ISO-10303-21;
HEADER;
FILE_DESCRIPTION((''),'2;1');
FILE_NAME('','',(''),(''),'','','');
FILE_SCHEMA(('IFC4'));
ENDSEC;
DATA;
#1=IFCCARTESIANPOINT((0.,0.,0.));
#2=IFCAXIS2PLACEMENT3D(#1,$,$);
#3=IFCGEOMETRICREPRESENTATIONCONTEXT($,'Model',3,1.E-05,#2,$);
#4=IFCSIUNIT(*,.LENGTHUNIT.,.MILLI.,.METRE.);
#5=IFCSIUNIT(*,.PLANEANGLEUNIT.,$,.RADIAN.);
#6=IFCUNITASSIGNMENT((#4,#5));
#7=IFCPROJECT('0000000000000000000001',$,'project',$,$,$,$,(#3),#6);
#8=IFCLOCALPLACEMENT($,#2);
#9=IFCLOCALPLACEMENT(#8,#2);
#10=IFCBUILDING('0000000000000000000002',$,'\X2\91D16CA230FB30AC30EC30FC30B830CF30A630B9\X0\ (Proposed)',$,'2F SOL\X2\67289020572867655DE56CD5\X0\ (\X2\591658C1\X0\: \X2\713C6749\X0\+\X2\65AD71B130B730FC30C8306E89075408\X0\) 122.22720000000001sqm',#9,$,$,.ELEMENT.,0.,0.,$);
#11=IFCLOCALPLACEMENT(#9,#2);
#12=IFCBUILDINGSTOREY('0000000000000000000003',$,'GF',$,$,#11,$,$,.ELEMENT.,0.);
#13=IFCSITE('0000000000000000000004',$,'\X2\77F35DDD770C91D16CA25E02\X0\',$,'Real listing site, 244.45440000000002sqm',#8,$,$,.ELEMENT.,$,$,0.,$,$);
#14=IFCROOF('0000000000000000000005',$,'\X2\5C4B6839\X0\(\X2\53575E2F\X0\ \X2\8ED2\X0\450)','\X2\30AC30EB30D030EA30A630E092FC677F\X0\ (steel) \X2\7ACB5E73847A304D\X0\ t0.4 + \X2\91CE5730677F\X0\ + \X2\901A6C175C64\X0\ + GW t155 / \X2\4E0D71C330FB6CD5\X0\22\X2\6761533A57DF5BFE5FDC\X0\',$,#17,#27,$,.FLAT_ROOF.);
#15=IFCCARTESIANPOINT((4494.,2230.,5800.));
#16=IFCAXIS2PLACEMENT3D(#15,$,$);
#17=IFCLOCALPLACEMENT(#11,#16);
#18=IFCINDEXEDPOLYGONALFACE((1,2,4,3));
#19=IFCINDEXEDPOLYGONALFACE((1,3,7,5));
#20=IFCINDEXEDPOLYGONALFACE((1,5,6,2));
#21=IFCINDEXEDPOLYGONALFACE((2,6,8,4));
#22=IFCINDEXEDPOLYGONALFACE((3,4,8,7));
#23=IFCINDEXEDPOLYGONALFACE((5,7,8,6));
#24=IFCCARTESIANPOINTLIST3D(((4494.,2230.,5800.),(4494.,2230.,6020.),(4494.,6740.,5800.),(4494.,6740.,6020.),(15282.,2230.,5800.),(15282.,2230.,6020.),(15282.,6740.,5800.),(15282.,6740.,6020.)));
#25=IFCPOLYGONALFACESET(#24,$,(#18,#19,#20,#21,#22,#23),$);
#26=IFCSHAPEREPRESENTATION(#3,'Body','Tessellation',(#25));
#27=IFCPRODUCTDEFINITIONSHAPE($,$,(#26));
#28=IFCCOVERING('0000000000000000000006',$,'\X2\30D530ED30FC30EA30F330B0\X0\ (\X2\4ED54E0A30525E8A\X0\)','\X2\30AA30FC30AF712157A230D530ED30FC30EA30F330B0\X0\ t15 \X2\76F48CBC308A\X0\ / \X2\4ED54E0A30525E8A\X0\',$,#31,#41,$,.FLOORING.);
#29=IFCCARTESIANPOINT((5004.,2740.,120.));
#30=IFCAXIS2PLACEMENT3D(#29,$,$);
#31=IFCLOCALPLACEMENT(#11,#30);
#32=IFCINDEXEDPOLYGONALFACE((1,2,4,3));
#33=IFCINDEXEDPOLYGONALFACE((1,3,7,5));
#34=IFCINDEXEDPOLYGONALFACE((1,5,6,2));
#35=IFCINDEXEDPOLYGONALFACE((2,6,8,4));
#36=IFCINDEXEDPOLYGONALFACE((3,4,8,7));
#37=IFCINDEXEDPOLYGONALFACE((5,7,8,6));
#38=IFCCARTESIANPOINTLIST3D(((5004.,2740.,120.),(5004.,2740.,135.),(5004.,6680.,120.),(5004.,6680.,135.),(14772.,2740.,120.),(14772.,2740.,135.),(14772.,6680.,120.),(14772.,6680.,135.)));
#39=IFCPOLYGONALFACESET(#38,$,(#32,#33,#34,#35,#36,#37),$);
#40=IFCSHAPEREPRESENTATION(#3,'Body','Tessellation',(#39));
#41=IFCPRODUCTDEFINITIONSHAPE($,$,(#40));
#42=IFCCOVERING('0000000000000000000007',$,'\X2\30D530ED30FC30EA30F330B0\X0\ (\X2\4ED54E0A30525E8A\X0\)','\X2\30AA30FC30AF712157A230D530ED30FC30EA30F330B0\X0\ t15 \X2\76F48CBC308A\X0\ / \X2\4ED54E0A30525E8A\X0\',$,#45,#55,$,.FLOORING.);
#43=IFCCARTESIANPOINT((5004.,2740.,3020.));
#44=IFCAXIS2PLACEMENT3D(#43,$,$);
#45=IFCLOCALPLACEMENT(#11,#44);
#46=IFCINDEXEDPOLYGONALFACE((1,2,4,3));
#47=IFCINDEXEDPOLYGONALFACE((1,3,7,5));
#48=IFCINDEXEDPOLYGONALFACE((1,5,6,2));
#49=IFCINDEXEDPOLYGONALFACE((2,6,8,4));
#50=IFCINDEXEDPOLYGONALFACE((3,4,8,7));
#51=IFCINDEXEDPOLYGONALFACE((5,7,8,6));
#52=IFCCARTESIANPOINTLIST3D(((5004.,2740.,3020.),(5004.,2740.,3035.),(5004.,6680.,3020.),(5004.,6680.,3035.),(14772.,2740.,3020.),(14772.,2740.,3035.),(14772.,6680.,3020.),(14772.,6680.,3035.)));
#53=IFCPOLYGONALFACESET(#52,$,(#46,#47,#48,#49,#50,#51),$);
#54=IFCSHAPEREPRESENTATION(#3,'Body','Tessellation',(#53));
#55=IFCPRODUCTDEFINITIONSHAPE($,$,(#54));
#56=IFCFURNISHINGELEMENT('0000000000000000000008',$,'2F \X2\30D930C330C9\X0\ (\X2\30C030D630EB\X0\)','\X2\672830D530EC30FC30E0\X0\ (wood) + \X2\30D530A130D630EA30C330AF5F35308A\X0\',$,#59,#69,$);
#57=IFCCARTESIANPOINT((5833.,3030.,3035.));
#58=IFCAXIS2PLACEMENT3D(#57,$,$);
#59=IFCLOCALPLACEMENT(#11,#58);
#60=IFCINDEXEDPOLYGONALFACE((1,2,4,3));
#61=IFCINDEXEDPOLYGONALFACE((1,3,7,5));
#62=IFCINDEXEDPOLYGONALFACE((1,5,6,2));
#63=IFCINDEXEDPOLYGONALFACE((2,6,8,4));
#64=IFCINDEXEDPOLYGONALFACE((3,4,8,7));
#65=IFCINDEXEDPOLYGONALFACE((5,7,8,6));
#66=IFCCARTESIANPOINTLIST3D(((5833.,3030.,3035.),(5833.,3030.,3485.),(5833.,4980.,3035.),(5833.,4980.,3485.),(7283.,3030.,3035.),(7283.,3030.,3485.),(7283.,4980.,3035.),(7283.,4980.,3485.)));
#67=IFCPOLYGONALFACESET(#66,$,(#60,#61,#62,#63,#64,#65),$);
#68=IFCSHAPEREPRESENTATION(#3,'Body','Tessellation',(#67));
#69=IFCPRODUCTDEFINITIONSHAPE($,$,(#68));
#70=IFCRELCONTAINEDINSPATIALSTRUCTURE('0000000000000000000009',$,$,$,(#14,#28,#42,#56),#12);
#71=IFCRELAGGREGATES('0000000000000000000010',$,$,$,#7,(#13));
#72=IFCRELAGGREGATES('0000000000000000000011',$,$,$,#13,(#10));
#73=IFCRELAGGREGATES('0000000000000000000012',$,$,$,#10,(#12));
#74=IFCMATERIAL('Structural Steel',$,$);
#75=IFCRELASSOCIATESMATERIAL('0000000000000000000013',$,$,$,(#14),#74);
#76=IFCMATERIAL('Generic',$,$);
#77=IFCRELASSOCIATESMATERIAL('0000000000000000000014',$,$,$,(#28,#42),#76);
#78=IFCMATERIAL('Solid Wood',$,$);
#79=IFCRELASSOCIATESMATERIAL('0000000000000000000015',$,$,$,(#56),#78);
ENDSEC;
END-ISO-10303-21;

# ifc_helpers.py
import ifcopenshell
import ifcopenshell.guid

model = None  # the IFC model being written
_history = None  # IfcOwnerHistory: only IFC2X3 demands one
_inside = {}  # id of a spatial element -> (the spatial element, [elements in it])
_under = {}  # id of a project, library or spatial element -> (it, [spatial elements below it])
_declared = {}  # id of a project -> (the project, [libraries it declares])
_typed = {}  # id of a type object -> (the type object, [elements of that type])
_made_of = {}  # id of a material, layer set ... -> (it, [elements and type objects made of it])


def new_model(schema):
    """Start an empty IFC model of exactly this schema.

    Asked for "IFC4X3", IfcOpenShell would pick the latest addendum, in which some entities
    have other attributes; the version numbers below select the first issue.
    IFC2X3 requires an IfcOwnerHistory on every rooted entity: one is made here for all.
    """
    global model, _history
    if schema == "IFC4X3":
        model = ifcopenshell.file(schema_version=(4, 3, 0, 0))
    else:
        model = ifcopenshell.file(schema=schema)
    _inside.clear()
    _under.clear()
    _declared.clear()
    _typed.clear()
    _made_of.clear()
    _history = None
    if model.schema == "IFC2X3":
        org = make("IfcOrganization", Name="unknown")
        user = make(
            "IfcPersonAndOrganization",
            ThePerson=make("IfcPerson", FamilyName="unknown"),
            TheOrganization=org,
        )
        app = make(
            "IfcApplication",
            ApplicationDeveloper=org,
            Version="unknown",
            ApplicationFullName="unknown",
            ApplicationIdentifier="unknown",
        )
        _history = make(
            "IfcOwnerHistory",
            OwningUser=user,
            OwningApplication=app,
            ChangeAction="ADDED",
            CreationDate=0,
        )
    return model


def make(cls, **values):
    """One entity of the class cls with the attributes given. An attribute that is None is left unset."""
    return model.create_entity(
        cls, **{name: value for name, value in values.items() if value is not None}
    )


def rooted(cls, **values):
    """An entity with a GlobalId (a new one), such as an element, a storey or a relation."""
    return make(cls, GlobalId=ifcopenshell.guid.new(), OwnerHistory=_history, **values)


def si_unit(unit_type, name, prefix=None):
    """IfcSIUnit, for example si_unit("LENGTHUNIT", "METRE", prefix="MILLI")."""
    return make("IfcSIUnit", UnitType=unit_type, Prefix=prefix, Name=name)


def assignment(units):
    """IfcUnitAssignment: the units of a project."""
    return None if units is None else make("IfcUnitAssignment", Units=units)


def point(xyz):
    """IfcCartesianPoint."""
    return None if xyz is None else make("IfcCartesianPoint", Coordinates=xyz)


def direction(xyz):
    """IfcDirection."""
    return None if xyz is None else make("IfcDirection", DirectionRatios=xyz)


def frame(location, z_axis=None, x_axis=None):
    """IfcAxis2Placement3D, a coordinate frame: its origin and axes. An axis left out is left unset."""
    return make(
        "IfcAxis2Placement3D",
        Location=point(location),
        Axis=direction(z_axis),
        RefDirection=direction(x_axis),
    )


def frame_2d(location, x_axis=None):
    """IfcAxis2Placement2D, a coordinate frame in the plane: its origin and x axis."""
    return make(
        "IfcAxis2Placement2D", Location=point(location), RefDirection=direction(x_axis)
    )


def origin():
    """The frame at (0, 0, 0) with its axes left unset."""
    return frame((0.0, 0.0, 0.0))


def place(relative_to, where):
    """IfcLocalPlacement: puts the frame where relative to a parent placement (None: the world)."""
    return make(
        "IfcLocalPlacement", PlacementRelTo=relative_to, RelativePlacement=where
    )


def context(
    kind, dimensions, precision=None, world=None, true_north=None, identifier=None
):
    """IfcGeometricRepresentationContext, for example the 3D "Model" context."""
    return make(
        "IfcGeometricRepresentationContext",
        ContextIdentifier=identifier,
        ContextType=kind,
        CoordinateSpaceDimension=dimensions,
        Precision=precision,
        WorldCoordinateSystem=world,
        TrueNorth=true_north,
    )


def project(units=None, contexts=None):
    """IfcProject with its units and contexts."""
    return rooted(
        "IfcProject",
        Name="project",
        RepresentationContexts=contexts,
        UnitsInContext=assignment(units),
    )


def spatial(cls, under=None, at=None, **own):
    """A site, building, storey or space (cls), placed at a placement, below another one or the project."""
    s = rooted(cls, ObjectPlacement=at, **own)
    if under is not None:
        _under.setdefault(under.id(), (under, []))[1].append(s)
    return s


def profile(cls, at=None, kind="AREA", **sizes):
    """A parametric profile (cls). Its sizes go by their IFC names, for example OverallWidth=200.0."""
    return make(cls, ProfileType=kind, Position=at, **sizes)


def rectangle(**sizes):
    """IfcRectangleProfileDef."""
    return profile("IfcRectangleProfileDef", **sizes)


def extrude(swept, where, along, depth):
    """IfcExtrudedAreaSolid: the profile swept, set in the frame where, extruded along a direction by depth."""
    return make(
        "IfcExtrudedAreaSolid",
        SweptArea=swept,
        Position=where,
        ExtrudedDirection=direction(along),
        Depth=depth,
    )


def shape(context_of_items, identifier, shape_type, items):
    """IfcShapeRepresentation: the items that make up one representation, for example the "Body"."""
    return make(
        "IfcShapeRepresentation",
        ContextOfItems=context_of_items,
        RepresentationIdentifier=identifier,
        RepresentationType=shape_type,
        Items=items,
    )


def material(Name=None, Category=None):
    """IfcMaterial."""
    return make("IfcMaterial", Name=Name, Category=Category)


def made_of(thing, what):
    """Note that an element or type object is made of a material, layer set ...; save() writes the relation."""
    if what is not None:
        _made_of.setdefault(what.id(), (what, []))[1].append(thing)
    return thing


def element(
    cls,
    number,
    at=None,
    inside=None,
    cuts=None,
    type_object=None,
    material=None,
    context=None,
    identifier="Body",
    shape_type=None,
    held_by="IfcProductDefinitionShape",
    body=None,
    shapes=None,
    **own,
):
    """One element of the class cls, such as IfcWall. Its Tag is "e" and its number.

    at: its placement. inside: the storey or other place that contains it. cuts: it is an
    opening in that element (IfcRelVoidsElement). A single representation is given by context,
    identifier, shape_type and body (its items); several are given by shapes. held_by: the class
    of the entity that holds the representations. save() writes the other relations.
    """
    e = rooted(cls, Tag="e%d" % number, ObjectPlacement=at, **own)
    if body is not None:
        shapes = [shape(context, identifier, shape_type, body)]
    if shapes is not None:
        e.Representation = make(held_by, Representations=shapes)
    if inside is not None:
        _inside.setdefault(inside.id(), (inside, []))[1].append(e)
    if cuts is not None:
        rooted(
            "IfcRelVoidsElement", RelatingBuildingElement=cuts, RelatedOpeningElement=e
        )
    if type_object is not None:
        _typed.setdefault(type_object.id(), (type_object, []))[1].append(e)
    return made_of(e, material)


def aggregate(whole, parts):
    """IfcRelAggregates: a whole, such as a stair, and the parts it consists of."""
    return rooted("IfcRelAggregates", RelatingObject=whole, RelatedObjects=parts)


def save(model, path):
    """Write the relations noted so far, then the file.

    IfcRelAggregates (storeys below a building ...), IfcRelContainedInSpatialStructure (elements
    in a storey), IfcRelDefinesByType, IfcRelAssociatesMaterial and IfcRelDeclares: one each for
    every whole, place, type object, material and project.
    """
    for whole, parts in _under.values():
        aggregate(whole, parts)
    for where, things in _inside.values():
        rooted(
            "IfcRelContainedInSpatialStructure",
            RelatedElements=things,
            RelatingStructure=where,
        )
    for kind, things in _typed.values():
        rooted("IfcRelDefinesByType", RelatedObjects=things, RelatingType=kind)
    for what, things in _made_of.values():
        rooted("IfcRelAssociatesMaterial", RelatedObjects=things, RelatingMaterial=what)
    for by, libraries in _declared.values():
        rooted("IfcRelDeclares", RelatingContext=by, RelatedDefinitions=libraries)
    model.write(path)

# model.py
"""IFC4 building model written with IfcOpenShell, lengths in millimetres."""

from ifc_helpers import new_model, si_unit, frame, frame_2d, origin, place, context, project, spatial, rectangle, extrude, material, element, save


model = new_model("IFC4")

# Units and contexts
model_context = context("Model", 3, precision=1e-05, world=origin())
ifc_project = project(units=[si_unit("LENGTHUNIT", "METRE", prefix="MILLI"), si_unit("PLANEANGLEUNIT", "RADIAN")], contexts=[model_context])

# Site, building, storey
site_placement = place(None, origin())
site = spatial("IfcSite", under=ifc_project, at=site_placement, Name="石川県金沢市", ObjectType="Real listing site, 244.45440000000002sqm", CompositionType="ELEMENT", RefElevation=0.0)
building_placement = place(site_placement, origin())
building = spatial("IfcBuilding", under=site, at=building_placement, Name="金沢・ガレージハウス (Proposed)", ObjectType="2F SOL木造在来工法 (外壁: 焼杉+断熱シートの複合) 122.22720000000001sqm", CompositionType="ELEMENT", ElevationOfRefHeight=0.0, ElevationOfTerrain=0.0)
storey_placement = place(building_placement, origin())
storey = spatial("IfcBuildingStorey", under=building, at=storey_placement, Name="GF", CompositionType="ELEMENT", Elevation=0.0)

# Shared definitions
ifc_material_1 = material(Name="Solid Wood")

# Roof
ifc_material_2 = material(Name="Structural Steel")
for number, where, name in (
    (1, (4494.0, 2230.0, 5800.0), "屋根(南帯 軒450)"),
):
    element("IfcRoof", number, at=place(storey_placement, frame(where)), inside=storey, material=ifc_material_2, Name=name, Description="ガルバリウム鋼板 (steel) 立平葺き t0.4 + 野地板 + 通気層 + GW t155 / 不燃・法22条区域対応", PredefinedType="FLAT_ROOF", context=model_context, shape_type="SweptSolid", body=[
        extrude(rectangle(XDim=10788.0, YDim=4510.0, at=frame_2d((5394.0, 2255.0))), frame((4494.0, 2230.0, 5800.0)), (0.0, 0.0, 1.0), 220.0),
    ])

# Coverings
ifc_material_3 = material(Name="Generic")
covering_1_placement = place(storey_placement, frame((5004.0, 2740.0, 120.0)))
element("IfcCovering", 2, at=covering_1_placement, inside=storey, material=ifc_material_3, Name="フローリング (仕上げ床)", Description="オーク無垢フローリング t15 直貼り / 仕上げ床", PredefinedType="FLOORING", context=model_context, shape_type="SweptSolid", body=[
    extrude(rectangle(XDim=9768.0, YDim=3940.0, at=frame_2d((4884.0, 1970.0))), frame((5004.0, 2740.0, 120.0)), (0.0, 0.0, 1.0), 15.0),
])
covering_2_placement = place(storey_placement, frame((5004.0, 2740.0, 3020.0)))
element("IfcCovering", 3, at=covering_2_placement, inside=storey, material=ifc_material_3, Name="フローリング (仕上げ床)", Description="オーク無垢フローリング t15 直貼り / 仕上げ床", PredefinedType="FLOORING", context=model_context, shape_type="SweptSolid", body=[
    extrude(rectangle(XDim=9768.0, YDim=3940.0, at=frame_2d((4884.0, 1970.0))), frame((5004.0, 2740.0, 3020.0)), (0.0, 0.0, 1.0), 15.0),
])

# Furnishing element
furnishing_placement = place(storey_placement, frame((5833.0, 3030.0, 3035.0)))
element("IfcFurnishingElement", 4, at=furnishing_placement, inside=storey, material=ifc_material_1, Name="2F ベッド (ダブル)", Description="木フレーム (wood) + ファブリック張り", context=model_context, shape_type="SweptSolid", body=[
    extrude(rectangle(XDim=1450.0, YDim=1950.0, at=frame_2d((725.0, 975.0))), frame((5833.0, 3030.0, 3035.0)), (0.0, 0.0, 1.0), 450.0),
])

save(model, "model.ifc")
